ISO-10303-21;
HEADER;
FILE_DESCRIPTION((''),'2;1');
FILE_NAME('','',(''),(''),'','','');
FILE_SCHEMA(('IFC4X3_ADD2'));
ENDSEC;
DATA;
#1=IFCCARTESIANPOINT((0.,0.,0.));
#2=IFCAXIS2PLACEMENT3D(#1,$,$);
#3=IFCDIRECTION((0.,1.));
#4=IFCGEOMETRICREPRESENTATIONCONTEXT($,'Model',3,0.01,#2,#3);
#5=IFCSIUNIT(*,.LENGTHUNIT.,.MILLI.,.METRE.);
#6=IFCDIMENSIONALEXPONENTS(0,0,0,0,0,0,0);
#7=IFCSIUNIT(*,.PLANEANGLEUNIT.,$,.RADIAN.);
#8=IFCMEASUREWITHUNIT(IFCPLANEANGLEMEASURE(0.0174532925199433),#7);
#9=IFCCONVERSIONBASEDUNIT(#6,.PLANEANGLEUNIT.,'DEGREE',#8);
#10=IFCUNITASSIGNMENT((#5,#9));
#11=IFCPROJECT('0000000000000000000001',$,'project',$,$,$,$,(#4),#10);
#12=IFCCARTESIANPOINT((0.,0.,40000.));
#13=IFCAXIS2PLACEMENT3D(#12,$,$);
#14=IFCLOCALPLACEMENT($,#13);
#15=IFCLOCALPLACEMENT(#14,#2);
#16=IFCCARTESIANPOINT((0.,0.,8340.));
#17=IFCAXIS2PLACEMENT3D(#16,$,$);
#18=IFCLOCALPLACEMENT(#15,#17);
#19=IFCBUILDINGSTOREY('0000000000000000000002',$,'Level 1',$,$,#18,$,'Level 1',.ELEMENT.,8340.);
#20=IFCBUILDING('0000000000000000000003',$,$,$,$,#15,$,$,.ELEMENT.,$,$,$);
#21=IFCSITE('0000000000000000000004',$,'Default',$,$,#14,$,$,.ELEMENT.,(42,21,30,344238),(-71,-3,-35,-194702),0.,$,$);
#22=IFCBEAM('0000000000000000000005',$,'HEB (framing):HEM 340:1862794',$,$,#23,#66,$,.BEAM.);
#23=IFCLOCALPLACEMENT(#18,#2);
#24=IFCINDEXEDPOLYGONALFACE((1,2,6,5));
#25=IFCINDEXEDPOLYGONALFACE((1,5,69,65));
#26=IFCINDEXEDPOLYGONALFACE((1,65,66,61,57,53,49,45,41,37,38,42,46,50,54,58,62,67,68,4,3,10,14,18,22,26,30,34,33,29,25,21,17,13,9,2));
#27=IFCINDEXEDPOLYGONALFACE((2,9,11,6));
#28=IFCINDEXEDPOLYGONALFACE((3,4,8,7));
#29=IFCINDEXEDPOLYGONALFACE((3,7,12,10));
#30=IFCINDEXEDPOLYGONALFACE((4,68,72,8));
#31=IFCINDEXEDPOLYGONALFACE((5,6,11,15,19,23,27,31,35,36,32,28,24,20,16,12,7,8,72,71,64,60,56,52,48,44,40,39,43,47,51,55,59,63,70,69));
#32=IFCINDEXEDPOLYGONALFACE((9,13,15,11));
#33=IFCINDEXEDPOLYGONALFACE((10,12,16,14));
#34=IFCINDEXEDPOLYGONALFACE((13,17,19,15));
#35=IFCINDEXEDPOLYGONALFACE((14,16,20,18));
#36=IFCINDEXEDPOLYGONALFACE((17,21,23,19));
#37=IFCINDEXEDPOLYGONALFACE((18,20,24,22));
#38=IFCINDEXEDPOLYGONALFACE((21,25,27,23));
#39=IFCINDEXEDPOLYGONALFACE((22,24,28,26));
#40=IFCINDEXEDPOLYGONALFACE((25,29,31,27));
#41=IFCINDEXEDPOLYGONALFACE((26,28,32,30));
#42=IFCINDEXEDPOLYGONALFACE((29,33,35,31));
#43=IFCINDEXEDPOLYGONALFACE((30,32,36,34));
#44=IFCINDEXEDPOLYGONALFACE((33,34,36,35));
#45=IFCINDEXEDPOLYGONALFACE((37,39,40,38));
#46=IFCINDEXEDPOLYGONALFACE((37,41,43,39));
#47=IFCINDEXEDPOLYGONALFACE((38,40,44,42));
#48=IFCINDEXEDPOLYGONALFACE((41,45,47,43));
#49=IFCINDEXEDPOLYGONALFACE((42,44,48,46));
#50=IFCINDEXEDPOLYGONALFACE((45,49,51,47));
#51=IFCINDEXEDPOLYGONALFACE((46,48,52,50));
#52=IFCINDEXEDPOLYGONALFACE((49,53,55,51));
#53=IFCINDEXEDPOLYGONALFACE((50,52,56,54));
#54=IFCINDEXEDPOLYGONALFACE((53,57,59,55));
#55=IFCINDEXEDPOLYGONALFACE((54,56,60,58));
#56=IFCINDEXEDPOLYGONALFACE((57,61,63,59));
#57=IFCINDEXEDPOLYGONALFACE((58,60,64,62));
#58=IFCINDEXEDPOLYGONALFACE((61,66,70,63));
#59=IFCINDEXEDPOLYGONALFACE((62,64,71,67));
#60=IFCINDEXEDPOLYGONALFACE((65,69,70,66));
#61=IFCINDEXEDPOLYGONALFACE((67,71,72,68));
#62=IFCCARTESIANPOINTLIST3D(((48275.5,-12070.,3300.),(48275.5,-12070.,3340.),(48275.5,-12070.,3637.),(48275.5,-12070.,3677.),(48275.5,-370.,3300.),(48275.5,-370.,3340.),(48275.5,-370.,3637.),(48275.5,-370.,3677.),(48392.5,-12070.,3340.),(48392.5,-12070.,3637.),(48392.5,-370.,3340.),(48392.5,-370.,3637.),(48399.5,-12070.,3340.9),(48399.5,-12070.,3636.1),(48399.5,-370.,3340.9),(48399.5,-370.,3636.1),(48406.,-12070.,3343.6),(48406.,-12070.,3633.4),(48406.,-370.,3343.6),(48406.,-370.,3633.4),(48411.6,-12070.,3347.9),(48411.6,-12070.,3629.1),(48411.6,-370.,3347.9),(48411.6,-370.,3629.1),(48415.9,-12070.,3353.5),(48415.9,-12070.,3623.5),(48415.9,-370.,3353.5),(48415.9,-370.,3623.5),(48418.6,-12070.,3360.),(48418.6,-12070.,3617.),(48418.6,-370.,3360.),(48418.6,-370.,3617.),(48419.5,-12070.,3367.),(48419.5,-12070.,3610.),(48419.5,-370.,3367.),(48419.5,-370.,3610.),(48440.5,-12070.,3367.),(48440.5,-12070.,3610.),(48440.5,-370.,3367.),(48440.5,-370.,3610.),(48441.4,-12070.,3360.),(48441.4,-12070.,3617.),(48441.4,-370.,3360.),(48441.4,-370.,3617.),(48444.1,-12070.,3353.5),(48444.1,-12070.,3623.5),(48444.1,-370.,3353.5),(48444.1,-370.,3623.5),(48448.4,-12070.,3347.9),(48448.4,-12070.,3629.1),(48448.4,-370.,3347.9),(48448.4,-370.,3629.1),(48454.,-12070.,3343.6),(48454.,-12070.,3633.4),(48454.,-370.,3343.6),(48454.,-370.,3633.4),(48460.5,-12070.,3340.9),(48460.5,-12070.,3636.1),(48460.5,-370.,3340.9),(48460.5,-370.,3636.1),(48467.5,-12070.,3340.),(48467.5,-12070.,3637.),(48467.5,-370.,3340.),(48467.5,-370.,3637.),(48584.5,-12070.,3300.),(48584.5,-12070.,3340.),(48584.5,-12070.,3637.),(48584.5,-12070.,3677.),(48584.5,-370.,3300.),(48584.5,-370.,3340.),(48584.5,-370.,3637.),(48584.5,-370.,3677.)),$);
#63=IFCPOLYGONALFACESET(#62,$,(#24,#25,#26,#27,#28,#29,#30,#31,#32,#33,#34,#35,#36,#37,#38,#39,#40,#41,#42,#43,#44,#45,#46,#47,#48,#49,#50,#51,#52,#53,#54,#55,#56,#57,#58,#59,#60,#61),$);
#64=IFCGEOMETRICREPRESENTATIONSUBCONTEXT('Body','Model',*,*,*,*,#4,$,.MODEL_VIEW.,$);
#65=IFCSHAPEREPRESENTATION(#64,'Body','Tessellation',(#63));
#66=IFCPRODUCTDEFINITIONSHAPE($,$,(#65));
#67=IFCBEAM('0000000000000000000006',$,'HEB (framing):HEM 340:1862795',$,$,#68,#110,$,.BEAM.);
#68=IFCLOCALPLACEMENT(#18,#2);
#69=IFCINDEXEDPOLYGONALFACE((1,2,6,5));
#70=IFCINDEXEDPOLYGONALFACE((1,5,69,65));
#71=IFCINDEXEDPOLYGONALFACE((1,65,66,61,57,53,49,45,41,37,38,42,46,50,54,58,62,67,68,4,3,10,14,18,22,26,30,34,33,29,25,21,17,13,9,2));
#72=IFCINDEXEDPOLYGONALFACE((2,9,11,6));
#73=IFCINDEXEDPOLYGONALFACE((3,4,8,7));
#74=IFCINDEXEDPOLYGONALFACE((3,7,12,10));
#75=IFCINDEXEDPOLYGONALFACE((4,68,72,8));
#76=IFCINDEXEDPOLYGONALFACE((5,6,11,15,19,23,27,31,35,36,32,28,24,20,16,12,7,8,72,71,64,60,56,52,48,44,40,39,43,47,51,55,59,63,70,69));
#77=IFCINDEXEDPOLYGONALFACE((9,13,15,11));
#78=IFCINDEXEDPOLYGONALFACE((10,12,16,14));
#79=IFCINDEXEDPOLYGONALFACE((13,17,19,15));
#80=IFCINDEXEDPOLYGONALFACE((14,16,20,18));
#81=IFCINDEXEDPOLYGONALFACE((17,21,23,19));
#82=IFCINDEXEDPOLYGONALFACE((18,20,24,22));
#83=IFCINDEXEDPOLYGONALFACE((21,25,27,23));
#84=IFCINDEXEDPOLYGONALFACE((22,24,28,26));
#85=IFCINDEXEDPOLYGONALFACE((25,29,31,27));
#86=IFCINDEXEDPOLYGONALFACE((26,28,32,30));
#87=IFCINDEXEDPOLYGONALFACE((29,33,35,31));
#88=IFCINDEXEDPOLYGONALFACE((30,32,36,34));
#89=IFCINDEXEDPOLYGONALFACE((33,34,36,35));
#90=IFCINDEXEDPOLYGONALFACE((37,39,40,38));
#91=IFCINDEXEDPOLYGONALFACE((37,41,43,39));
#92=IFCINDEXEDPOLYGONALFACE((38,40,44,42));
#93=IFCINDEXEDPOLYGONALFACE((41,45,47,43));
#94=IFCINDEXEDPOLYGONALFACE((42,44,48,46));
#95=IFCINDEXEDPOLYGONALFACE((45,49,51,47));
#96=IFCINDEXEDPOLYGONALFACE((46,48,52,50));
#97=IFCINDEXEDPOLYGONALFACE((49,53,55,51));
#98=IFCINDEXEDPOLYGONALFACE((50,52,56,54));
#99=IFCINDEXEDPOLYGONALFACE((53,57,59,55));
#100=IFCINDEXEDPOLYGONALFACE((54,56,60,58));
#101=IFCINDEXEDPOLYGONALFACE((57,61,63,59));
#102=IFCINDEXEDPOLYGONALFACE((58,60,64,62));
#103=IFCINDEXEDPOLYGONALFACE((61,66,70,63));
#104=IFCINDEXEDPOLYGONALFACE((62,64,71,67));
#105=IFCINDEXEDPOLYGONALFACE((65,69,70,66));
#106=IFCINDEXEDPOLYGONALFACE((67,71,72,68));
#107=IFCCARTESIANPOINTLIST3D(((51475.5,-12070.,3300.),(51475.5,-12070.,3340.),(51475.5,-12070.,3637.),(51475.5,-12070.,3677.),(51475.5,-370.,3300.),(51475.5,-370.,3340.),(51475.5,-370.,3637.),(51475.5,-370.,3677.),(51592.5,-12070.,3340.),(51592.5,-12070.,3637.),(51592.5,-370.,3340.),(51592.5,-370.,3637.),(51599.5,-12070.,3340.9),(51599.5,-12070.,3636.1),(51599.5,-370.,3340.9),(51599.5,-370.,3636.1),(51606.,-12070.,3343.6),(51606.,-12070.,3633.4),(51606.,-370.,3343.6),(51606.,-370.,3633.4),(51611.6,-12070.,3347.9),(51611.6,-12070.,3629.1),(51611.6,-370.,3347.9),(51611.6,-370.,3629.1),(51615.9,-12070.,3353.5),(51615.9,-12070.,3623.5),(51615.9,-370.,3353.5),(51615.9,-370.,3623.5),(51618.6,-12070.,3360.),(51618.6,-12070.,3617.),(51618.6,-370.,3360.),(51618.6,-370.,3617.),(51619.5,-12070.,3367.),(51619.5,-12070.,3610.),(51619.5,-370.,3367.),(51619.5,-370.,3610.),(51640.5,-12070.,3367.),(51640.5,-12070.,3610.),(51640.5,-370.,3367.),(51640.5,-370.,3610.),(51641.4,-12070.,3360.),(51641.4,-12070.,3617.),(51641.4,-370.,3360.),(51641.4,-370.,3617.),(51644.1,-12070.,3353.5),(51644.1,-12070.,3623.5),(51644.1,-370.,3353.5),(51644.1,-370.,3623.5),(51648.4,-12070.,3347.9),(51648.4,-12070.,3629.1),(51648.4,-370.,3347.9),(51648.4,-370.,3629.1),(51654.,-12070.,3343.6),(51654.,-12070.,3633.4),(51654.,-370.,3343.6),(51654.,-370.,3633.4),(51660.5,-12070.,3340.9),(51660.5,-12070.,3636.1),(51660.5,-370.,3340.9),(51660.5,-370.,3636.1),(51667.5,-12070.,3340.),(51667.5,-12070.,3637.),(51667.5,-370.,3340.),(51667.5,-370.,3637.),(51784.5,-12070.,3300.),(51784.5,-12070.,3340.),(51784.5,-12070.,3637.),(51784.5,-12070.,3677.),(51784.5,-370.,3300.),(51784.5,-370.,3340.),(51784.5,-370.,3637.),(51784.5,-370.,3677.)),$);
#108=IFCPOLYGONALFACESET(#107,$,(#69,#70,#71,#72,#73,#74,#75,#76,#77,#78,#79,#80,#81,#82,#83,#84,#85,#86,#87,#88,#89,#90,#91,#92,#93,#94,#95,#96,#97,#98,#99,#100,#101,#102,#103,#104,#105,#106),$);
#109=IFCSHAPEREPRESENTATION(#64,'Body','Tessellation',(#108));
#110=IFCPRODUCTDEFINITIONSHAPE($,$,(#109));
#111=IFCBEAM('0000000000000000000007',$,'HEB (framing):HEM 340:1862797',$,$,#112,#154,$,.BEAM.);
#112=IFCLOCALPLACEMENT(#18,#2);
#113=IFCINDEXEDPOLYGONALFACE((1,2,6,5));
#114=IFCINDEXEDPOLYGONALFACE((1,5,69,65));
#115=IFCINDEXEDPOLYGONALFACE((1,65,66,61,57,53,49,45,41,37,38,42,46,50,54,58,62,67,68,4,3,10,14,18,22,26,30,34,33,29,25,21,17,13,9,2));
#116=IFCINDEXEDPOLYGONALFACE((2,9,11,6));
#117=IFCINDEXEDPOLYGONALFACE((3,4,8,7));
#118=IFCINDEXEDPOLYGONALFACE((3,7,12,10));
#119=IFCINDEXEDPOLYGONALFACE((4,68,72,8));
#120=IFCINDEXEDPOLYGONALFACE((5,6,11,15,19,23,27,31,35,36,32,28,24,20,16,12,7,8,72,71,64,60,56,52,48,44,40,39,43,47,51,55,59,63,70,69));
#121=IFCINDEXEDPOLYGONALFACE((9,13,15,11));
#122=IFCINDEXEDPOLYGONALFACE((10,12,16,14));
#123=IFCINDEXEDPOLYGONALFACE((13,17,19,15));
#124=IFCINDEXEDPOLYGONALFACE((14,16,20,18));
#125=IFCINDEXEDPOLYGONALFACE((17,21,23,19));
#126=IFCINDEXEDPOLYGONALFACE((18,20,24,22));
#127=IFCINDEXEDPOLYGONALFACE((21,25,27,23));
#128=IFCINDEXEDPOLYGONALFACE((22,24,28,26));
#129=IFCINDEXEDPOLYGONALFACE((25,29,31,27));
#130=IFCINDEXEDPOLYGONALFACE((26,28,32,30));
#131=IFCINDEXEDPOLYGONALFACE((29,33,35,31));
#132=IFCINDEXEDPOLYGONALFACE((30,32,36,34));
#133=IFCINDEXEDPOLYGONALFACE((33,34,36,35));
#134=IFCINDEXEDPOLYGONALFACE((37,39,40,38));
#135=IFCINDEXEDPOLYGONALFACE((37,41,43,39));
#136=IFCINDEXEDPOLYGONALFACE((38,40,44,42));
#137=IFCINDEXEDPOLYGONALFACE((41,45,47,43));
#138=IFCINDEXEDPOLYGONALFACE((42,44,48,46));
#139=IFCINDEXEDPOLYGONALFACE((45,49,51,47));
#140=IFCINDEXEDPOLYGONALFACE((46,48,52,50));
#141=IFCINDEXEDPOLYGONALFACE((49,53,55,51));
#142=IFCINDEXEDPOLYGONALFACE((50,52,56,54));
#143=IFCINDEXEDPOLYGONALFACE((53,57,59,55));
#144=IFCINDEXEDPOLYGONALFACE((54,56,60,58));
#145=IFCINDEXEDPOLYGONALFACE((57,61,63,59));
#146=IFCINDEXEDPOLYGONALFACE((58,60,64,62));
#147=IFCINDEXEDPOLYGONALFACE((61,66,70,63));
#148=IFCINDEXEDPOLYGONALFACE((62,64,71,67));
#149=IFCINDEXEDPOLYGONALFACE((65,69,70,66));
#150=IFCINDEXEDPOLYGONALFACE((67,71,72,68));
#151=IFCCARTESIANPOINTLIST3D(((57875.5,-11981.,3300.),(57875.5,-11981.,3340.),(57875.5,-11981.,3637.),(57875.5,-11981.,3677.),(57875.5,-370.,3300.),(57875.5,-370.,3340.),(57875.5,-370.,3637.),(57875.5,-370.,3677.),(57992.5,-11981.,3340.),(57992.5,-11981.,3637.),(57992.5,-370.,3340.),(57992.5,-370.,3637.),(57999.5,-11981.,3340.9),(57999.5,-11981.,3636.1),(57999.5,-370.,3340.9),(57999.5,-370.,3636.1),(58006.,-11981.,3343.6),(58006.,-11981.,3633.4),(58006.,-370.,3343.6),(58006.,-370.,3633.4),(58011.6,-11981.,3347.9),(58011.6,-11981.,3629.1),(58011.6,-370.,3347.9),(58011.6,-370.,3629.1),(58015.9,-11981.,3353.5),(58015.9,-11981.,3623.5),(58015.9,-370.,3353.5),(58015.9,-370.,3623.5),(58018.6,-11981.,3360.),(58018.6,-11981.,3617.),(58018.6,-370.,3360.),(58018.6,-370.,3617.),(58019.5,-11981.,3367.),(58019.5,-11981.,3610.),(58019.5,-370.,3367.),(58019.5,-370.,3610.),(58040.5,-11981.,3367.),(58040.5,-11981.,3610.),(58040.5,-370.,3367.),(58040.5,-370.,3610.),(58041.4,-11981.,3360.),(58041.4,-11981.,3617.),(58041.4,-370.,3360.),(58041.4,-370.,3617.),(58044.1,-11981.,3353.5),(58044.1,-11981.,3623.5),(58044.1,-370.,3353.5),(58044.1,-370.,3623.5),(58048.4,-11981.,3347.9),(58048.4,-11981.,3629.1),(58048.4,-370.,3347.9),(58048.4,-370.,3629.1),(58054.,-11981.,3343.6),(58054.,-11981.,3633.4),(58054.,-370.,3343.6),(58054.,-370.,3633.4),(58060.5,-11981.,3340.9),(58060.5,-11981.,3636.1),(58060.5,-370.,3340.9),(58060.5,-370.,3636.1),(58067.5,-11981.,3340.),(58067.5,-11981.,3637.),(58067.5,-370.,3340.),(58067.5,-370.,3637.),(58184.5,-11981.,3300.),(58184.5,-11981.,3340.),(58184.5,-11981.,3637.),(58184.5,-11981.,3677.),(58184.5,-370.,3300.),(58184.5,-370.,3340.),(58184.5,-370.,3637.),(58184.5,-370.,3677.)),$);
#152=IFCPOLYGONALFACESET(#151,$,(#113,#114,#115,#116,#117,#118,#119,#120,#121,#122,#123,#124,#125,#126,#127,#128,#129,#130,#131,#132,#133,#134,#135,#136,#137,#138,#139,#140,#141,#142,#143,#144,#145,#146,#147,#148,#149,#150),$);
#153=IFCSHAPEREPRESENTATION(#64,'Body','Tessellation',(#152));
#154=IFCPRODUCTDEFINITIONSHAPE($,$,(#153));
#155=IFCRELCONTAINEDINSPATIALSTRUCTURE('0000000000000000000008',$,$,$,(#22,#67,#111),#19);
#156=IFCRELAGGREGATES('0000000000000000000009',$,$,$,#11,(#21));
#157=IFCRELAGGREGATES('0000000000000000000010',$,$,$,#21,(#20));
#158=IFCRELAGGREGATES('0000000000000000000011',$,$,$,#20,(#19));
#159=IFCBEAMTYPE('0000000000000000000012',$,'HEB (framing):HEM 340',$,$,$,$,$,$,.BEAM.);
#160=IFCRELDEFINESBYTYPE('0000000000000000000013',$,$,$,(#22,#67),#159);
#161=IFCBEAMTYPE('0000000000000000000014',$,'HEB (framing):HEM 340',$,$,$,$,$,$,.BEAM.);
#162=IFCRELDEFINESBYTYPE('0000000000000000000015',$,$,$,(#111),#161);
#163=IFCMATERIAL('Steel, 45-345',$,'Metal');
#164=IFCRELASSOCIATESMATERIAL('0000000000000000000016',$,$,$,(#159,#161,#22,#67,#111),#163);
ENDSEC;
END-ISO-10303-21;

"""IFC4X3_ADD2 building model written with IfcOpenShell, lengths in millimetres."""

from ifc_helpers import new_model, entity, si_unit, converted_unit, direction, frame, frame_2d, origin, place, context, subcontext, project, spatial, polyline, circle_curve, parameter, trimmed, segment, composite_curve, outline, extrude, source, transform, mapped, material, material_profile, profile_set, profile_usage, type_object, type_shapes, element, save


model = new_model("IFC4X3_ADD2")

# Units and contexts
model_context = context("Model", 3, precision=0.01, world=origin(), true_north=direction((0.0, 1.0)))
body_context = subcontext(model_context, "Body", "Model", "MODEL_VIEW")
ifc_project = project(units=[si_unit("LENGTHUNIT", "METRE", prefix="MILLI"), converted_unit("PLANEANGLEUNIT", "DEGREE", entity("IfcPlaneAngleMeasure", 0.0174532925199433), si_unit("PLANEANGLEUNIT", "RADIAN"), dimensions=[0, 0, 0, 0, 0, 0, 0])], contexts=[model_context])

# Site, building, storey
site_placement = place(None, frame((0.0, 0.0, 40000.0)))
site = spatial("IfcSite", under=ifc_project, at=site_placement, Name="Default", CompositionType="ELEMENT", RefLatitude=(42, 21, 30, 344238), RefLongitude=(-71, -3, -35, -194702), RefElevation=0.0)
building_placement = place(site_placement, origin())
building = spatial("IfcBuilding", under=site, at=building_placement, CompositionType="ELEMENT")
storey_placement = place(building_placement, frame((0.0, 0.0, 8340.0)))
storey = spatial("IfcBuildingStorey", under=building, at=storey_placement, Name="Level 1", LongName="Level 1", CompositionType="ELEMENT", Elevation=8340.0)

# Shared definitions
ifc_material = material(Name="Steel, 45-345", Category="Metal")

# Beams
ifc_material_profile_1 = material_profile(ifc_material, outline(composite_curve([segment(polyline([(-154.5, -148.5), (-154.5, -188.5)]), True, "CONTINUOUS"), segment(polyline([(-154.5, -188.5), (154.5, -188.5)]), True, "CONTINUOUS"), segment(polyline([(154.5, -188.5), (154.5, -148.5)]), True, "CONTINUOUS"), segment(polyline([(154.5, -148.5), (37.5, -148.5)]), True, "CONTINUOUS"), segment(trimmed(circle_curve(frame_2d((37.5, -121.5), x_axis=(1.0, 0.0)), 27.0), [parameter(180.0)], [parameter(270.0)], True, "PARAMETER"), False, "CONTINUOUS"), segment(polyline([(10.5, -121.5), (10.5, 121.5)]), True, "CONTINUOUS"), segment(trimmed(circle_curve(frame_2d((37.5, 121.5), x_axis=(1.0, 0.0)), 27.0), [parameter(90.0)], [parameter(180.0)], True, "PARAMETER"), False, "CONTINUOUS"), segment(polyline([(37.5, 148.5), (154.5, 148.5)]), True, "CONTINUOUS"), segment(polyline([(154.5, 148.5), (154.5, 188.5)]), True, "CONTINUOUS"), segment(polyline([(154.5, 188.5), (-154.5, 188.5)]), True, "CONTINUOUS"), segment(polyline([(-154.5, 188.5), (-154.5, 148.5)]), True, "CONTINUOUS"), segment(polyline([(-154.5, 148.5), (-37.5, 148.5)]), True, "CONTINUOUS"), segment(trimmed(circle_curve(frame_2d((-37.5, 121.5), x_axis=(1.0, 0.0)), 27.0), [parameter(360.0)], [parameter(90.0)], True, "PARAMETER"), False, "CONTINUOUS"), segment(polyline([(-10.5, 121.5), (-10.5, -121.5)]), True, "CONTINUOUS"), segment(trimmed(circle_curve(frame_2d((-37.5, -121.5), x_axis=(1.0, 0.0)), 27.0), [parameter(270.0)], [parameter(0.0)], True, "PARAMETER"), False, "CONTINUOUS"), segment(polyline([(-37.5, -148.5), (-154.5, -148.5)]), True, "CONTINUOUS")], self_intersect=False)), Name="HEM 340")
ifc_profile_set_1 = profile_set([ifc_material_profile_1], Name="HEM 340")
ifc_profile_usage_1 = profile_usage(ifc_profile_set_1, cardinal=8)
beam_type_1 = type_object("IfcBeamType", Name="HEB (framing):HEM 340", PredefinedType="BEAM", material=ifc_profile_set_1)
shared_shape_1 = source(origin(), body_context, "Body", "SweptSolid", [
    extrude(outline(composite_curve([segment(polyline([(-154.5, -148.5), (-154.5, -188.5)]), True, "CONTINUOUS"), segment(polyline([(-154.5, -188.5), (154.5, -188.5)]), True, "CONTINUOUS"), segment(polyline([(154.5, -188.5), (154.5, -148.5)]), True, "CONTINUOUS"), segment(polyline([(154.5, -148.5), (37.5, -148.5)]), True, "CONTINUOUS"), segment(trimmed(circle_curve(frame_2d((37.5, -121.5), x_axis=(1.0, 0.0)), 27.0), [parameter(180.0)], [parameter(270.0)], True, "PARAMETER"), False, "CONTINUOUS"), segment(polyline([(10.5, -121.5), (10.5, 121.5)]), True, "CONTINUOUS"), segment(trimmed(circle_curve(frame_2d((37.5, 121.5), x_axis=(1.0, 0.0)), 27.0), [parameter(90.0)], [parameter(180.0)], True, "PARAMETER"), False, "CONTINUOUS"), segment(polyline([(37.5, 148.5), (154.5, 148.5)]), True, "CONTINUOUS"), segment(polyline([(154.5, 148.5), (154.5, 188.5)]), True, "CONTINUOUS"), segment(polyline([(154.5, 188.5), (-154.5, 188.5)]), True, "CONTINUOUS"), segment(polyline([(-154.5, 188.5), (-154.5, 148.5)]), True, "CONTINUOUS"), segment(polyline([(-154.5, 148.5), (-37.5, 148.5)]), True, "CONTINUOUS"), segment(trimmed(circle_curve(frame_2d((-37.5, 121.5), x_axis=(1.0, 0.0)), 27.0), [parameter(360.0)], [parameter(90.0)], True, "PARAMETER"), False, "CONTINUOUS"), segment(polyline([(-10.5, 121.5), (-10.5, -121.5)]), True, "CONTINUOUS"), segment(trimmed(circle_curve(frame_2d((-37.5, -121.5), x_axis=(1.0, 0.0)), 27.0), [parameter(270.0)], [parameter(0.0)], True, "PARAMETER"), False, "CONTINUOUS"), segment(polyline([(-37.5, -148.5), (-154.5, -148.5)]), True, "CONTINUOUS")], self_intersect=False)), frame((-5850.0, 0.0, 0.0), z_axis=(-1.0, 0.0, 0.0), x_axis=(0.0, -1.0, 0.0)), (0.0, 0.0, -1.0), 11700.0),
])
type_shapes(beam_type_1, [shared_shape_1])
for number, where, z_axis, x_axis, name in (
    (1, (48430.0, -6220.0, 3488.5), (0.0, 0.0, 1.0), (0.0, -1.0, 0.0), "HEB (framing):HEM 340:1862794"),
    (2, (51630.0, -6220.0, 3488.5), (0.0, 0.0, 1.0), (0.0, -1.0, 0.0), "HEB (framing):HEM 340:1862795"),
):
    element("IfcBeam", number, at=place(storey_placement, frame(where, z_axis=z_axis, x_axis=x_axis)), inside=storey, type_object=beam_type_1, material=ifc_profile_usage_1, Name=name, PredefinedType="BEAM", context=body_context, shape_type="MappedRepresentation", body=[
        mapped(shared_shape_1, transform((0.0, 0.0, 0.0), scale=1.0)),
    ])
beam_type_2 = type_object("IfcBeamType", Name="HEB (framing):HEM 340", PredefinedType="BEAM", material=ifc_profile_set_1)
shared_shape_2 = source(origin(), body_context, "Body", "SweptSolid", [
    extrude(outline(composite_curve([segment(polyline([(-154.5, -148.5), (-154.5, -188.5)]), True, "CONTINUOUS"), segment(polyline([(-154.5, -188.5), (154.5, -188.5)]), True, "CONTINUOUS"), segment(polyline([(154.5, -188.5), (154.5, -148.5)]), True, "CONTINUOUS"), segment(polyline([(154.5, -148.5), (37.5, -148.5)]), True, "CONTINUOUS"), segment(trimmed(circle_curve(frame_2d((37.5, -121.5), x_axis=(1.0, 0.0)), 27.0), [parameter(180.0)], [parameter(270.0)], True, "PARAMETER"), False, "CONTINUOUS"), segment(polyline([(10.5, -121.5), (10.5, 121.5)]), True, "CONTINUOUS"), segment(trimmed(circle_curve(frame_2d((37.5, 121.5), x_axis=(1.0, 0.0)), 27.0), [parameter(90.0)], [parameter(180.0)], True, "PARAMETER"), False, "CONTINUOUS"), segment(polyline([(37.5, 148.5), (154.5, 148.5)]), True, "CONTINUOUS"), segment(polyline([(154.5, 148.5), (154.5, 188.5)]), True, "CONTINUOUS"), segment(polyline([(154.5, 188.5), (-154.5, 188.5)]), True, "CONTINUOUS"), segment(polyline([(-154.5, 188.5), (-154.5, 148.5)]), True, "CONTINUOUS"), segment(polyline([(-154.5, 148.5), (-37.5, 148.5)]), True, "CONTINUOUS"), segment(trimmed(circle_curve(frame_2d((-37.5, 121.5), x_axis=(1.0, 0.0)), 27.0), [parameter(360.0)], [parameter(90.0)], True, "PARAMETER"), False, "CONTINUOUS"), segment(polyline([(-10.5, 121.5), (-10.5, -121.5)]), True, "CONTINUOUS"), segment(trimmed(circle_curve(frame_2d((-37.5, -121.5), x_axis=(1.0, 0.0)), 27.0), [parameter(270.0)], [parameter(0.0)], True, "PARAMETER"), False, "CONTINUOUS"), segment(polyline([(-37.5, -148.5), (-154.5, -148.5)]), True, "CONTINUOUS")], self_intersect=False)), frame((-5850.0, 0.0, 0.0), z_axis=(-1.0, 0.0, 0.0), x_axis=(0.0, -1.0, 0.0)), (0.0, 0.0, -1.0), 11611.0),
])
type_shapes(beam_type_2, [shared_shape_2])
beam_1_placement = place(storey_placement, frame((58030.0, -6220.0, 3488.5), z_axis=(0.0, 0.0, 1.0), x_axis=(0.0, -1.0, 0.0)))
element("IfcBeam", 3, at=beam_1_placement, inside=storey, type_object=beam_type_2, material=ifc_profile_usage_1, Name="HEB (framing):HEM 340:1862797", PredefinedType="BEAM", context=body_context, shape_type="MappedRepresentation", body=[
    mapped(shared_shape_2, transform((0.0, 0.0, 0.0), scale=1.0)),
])

save(model, "model.ifc")
